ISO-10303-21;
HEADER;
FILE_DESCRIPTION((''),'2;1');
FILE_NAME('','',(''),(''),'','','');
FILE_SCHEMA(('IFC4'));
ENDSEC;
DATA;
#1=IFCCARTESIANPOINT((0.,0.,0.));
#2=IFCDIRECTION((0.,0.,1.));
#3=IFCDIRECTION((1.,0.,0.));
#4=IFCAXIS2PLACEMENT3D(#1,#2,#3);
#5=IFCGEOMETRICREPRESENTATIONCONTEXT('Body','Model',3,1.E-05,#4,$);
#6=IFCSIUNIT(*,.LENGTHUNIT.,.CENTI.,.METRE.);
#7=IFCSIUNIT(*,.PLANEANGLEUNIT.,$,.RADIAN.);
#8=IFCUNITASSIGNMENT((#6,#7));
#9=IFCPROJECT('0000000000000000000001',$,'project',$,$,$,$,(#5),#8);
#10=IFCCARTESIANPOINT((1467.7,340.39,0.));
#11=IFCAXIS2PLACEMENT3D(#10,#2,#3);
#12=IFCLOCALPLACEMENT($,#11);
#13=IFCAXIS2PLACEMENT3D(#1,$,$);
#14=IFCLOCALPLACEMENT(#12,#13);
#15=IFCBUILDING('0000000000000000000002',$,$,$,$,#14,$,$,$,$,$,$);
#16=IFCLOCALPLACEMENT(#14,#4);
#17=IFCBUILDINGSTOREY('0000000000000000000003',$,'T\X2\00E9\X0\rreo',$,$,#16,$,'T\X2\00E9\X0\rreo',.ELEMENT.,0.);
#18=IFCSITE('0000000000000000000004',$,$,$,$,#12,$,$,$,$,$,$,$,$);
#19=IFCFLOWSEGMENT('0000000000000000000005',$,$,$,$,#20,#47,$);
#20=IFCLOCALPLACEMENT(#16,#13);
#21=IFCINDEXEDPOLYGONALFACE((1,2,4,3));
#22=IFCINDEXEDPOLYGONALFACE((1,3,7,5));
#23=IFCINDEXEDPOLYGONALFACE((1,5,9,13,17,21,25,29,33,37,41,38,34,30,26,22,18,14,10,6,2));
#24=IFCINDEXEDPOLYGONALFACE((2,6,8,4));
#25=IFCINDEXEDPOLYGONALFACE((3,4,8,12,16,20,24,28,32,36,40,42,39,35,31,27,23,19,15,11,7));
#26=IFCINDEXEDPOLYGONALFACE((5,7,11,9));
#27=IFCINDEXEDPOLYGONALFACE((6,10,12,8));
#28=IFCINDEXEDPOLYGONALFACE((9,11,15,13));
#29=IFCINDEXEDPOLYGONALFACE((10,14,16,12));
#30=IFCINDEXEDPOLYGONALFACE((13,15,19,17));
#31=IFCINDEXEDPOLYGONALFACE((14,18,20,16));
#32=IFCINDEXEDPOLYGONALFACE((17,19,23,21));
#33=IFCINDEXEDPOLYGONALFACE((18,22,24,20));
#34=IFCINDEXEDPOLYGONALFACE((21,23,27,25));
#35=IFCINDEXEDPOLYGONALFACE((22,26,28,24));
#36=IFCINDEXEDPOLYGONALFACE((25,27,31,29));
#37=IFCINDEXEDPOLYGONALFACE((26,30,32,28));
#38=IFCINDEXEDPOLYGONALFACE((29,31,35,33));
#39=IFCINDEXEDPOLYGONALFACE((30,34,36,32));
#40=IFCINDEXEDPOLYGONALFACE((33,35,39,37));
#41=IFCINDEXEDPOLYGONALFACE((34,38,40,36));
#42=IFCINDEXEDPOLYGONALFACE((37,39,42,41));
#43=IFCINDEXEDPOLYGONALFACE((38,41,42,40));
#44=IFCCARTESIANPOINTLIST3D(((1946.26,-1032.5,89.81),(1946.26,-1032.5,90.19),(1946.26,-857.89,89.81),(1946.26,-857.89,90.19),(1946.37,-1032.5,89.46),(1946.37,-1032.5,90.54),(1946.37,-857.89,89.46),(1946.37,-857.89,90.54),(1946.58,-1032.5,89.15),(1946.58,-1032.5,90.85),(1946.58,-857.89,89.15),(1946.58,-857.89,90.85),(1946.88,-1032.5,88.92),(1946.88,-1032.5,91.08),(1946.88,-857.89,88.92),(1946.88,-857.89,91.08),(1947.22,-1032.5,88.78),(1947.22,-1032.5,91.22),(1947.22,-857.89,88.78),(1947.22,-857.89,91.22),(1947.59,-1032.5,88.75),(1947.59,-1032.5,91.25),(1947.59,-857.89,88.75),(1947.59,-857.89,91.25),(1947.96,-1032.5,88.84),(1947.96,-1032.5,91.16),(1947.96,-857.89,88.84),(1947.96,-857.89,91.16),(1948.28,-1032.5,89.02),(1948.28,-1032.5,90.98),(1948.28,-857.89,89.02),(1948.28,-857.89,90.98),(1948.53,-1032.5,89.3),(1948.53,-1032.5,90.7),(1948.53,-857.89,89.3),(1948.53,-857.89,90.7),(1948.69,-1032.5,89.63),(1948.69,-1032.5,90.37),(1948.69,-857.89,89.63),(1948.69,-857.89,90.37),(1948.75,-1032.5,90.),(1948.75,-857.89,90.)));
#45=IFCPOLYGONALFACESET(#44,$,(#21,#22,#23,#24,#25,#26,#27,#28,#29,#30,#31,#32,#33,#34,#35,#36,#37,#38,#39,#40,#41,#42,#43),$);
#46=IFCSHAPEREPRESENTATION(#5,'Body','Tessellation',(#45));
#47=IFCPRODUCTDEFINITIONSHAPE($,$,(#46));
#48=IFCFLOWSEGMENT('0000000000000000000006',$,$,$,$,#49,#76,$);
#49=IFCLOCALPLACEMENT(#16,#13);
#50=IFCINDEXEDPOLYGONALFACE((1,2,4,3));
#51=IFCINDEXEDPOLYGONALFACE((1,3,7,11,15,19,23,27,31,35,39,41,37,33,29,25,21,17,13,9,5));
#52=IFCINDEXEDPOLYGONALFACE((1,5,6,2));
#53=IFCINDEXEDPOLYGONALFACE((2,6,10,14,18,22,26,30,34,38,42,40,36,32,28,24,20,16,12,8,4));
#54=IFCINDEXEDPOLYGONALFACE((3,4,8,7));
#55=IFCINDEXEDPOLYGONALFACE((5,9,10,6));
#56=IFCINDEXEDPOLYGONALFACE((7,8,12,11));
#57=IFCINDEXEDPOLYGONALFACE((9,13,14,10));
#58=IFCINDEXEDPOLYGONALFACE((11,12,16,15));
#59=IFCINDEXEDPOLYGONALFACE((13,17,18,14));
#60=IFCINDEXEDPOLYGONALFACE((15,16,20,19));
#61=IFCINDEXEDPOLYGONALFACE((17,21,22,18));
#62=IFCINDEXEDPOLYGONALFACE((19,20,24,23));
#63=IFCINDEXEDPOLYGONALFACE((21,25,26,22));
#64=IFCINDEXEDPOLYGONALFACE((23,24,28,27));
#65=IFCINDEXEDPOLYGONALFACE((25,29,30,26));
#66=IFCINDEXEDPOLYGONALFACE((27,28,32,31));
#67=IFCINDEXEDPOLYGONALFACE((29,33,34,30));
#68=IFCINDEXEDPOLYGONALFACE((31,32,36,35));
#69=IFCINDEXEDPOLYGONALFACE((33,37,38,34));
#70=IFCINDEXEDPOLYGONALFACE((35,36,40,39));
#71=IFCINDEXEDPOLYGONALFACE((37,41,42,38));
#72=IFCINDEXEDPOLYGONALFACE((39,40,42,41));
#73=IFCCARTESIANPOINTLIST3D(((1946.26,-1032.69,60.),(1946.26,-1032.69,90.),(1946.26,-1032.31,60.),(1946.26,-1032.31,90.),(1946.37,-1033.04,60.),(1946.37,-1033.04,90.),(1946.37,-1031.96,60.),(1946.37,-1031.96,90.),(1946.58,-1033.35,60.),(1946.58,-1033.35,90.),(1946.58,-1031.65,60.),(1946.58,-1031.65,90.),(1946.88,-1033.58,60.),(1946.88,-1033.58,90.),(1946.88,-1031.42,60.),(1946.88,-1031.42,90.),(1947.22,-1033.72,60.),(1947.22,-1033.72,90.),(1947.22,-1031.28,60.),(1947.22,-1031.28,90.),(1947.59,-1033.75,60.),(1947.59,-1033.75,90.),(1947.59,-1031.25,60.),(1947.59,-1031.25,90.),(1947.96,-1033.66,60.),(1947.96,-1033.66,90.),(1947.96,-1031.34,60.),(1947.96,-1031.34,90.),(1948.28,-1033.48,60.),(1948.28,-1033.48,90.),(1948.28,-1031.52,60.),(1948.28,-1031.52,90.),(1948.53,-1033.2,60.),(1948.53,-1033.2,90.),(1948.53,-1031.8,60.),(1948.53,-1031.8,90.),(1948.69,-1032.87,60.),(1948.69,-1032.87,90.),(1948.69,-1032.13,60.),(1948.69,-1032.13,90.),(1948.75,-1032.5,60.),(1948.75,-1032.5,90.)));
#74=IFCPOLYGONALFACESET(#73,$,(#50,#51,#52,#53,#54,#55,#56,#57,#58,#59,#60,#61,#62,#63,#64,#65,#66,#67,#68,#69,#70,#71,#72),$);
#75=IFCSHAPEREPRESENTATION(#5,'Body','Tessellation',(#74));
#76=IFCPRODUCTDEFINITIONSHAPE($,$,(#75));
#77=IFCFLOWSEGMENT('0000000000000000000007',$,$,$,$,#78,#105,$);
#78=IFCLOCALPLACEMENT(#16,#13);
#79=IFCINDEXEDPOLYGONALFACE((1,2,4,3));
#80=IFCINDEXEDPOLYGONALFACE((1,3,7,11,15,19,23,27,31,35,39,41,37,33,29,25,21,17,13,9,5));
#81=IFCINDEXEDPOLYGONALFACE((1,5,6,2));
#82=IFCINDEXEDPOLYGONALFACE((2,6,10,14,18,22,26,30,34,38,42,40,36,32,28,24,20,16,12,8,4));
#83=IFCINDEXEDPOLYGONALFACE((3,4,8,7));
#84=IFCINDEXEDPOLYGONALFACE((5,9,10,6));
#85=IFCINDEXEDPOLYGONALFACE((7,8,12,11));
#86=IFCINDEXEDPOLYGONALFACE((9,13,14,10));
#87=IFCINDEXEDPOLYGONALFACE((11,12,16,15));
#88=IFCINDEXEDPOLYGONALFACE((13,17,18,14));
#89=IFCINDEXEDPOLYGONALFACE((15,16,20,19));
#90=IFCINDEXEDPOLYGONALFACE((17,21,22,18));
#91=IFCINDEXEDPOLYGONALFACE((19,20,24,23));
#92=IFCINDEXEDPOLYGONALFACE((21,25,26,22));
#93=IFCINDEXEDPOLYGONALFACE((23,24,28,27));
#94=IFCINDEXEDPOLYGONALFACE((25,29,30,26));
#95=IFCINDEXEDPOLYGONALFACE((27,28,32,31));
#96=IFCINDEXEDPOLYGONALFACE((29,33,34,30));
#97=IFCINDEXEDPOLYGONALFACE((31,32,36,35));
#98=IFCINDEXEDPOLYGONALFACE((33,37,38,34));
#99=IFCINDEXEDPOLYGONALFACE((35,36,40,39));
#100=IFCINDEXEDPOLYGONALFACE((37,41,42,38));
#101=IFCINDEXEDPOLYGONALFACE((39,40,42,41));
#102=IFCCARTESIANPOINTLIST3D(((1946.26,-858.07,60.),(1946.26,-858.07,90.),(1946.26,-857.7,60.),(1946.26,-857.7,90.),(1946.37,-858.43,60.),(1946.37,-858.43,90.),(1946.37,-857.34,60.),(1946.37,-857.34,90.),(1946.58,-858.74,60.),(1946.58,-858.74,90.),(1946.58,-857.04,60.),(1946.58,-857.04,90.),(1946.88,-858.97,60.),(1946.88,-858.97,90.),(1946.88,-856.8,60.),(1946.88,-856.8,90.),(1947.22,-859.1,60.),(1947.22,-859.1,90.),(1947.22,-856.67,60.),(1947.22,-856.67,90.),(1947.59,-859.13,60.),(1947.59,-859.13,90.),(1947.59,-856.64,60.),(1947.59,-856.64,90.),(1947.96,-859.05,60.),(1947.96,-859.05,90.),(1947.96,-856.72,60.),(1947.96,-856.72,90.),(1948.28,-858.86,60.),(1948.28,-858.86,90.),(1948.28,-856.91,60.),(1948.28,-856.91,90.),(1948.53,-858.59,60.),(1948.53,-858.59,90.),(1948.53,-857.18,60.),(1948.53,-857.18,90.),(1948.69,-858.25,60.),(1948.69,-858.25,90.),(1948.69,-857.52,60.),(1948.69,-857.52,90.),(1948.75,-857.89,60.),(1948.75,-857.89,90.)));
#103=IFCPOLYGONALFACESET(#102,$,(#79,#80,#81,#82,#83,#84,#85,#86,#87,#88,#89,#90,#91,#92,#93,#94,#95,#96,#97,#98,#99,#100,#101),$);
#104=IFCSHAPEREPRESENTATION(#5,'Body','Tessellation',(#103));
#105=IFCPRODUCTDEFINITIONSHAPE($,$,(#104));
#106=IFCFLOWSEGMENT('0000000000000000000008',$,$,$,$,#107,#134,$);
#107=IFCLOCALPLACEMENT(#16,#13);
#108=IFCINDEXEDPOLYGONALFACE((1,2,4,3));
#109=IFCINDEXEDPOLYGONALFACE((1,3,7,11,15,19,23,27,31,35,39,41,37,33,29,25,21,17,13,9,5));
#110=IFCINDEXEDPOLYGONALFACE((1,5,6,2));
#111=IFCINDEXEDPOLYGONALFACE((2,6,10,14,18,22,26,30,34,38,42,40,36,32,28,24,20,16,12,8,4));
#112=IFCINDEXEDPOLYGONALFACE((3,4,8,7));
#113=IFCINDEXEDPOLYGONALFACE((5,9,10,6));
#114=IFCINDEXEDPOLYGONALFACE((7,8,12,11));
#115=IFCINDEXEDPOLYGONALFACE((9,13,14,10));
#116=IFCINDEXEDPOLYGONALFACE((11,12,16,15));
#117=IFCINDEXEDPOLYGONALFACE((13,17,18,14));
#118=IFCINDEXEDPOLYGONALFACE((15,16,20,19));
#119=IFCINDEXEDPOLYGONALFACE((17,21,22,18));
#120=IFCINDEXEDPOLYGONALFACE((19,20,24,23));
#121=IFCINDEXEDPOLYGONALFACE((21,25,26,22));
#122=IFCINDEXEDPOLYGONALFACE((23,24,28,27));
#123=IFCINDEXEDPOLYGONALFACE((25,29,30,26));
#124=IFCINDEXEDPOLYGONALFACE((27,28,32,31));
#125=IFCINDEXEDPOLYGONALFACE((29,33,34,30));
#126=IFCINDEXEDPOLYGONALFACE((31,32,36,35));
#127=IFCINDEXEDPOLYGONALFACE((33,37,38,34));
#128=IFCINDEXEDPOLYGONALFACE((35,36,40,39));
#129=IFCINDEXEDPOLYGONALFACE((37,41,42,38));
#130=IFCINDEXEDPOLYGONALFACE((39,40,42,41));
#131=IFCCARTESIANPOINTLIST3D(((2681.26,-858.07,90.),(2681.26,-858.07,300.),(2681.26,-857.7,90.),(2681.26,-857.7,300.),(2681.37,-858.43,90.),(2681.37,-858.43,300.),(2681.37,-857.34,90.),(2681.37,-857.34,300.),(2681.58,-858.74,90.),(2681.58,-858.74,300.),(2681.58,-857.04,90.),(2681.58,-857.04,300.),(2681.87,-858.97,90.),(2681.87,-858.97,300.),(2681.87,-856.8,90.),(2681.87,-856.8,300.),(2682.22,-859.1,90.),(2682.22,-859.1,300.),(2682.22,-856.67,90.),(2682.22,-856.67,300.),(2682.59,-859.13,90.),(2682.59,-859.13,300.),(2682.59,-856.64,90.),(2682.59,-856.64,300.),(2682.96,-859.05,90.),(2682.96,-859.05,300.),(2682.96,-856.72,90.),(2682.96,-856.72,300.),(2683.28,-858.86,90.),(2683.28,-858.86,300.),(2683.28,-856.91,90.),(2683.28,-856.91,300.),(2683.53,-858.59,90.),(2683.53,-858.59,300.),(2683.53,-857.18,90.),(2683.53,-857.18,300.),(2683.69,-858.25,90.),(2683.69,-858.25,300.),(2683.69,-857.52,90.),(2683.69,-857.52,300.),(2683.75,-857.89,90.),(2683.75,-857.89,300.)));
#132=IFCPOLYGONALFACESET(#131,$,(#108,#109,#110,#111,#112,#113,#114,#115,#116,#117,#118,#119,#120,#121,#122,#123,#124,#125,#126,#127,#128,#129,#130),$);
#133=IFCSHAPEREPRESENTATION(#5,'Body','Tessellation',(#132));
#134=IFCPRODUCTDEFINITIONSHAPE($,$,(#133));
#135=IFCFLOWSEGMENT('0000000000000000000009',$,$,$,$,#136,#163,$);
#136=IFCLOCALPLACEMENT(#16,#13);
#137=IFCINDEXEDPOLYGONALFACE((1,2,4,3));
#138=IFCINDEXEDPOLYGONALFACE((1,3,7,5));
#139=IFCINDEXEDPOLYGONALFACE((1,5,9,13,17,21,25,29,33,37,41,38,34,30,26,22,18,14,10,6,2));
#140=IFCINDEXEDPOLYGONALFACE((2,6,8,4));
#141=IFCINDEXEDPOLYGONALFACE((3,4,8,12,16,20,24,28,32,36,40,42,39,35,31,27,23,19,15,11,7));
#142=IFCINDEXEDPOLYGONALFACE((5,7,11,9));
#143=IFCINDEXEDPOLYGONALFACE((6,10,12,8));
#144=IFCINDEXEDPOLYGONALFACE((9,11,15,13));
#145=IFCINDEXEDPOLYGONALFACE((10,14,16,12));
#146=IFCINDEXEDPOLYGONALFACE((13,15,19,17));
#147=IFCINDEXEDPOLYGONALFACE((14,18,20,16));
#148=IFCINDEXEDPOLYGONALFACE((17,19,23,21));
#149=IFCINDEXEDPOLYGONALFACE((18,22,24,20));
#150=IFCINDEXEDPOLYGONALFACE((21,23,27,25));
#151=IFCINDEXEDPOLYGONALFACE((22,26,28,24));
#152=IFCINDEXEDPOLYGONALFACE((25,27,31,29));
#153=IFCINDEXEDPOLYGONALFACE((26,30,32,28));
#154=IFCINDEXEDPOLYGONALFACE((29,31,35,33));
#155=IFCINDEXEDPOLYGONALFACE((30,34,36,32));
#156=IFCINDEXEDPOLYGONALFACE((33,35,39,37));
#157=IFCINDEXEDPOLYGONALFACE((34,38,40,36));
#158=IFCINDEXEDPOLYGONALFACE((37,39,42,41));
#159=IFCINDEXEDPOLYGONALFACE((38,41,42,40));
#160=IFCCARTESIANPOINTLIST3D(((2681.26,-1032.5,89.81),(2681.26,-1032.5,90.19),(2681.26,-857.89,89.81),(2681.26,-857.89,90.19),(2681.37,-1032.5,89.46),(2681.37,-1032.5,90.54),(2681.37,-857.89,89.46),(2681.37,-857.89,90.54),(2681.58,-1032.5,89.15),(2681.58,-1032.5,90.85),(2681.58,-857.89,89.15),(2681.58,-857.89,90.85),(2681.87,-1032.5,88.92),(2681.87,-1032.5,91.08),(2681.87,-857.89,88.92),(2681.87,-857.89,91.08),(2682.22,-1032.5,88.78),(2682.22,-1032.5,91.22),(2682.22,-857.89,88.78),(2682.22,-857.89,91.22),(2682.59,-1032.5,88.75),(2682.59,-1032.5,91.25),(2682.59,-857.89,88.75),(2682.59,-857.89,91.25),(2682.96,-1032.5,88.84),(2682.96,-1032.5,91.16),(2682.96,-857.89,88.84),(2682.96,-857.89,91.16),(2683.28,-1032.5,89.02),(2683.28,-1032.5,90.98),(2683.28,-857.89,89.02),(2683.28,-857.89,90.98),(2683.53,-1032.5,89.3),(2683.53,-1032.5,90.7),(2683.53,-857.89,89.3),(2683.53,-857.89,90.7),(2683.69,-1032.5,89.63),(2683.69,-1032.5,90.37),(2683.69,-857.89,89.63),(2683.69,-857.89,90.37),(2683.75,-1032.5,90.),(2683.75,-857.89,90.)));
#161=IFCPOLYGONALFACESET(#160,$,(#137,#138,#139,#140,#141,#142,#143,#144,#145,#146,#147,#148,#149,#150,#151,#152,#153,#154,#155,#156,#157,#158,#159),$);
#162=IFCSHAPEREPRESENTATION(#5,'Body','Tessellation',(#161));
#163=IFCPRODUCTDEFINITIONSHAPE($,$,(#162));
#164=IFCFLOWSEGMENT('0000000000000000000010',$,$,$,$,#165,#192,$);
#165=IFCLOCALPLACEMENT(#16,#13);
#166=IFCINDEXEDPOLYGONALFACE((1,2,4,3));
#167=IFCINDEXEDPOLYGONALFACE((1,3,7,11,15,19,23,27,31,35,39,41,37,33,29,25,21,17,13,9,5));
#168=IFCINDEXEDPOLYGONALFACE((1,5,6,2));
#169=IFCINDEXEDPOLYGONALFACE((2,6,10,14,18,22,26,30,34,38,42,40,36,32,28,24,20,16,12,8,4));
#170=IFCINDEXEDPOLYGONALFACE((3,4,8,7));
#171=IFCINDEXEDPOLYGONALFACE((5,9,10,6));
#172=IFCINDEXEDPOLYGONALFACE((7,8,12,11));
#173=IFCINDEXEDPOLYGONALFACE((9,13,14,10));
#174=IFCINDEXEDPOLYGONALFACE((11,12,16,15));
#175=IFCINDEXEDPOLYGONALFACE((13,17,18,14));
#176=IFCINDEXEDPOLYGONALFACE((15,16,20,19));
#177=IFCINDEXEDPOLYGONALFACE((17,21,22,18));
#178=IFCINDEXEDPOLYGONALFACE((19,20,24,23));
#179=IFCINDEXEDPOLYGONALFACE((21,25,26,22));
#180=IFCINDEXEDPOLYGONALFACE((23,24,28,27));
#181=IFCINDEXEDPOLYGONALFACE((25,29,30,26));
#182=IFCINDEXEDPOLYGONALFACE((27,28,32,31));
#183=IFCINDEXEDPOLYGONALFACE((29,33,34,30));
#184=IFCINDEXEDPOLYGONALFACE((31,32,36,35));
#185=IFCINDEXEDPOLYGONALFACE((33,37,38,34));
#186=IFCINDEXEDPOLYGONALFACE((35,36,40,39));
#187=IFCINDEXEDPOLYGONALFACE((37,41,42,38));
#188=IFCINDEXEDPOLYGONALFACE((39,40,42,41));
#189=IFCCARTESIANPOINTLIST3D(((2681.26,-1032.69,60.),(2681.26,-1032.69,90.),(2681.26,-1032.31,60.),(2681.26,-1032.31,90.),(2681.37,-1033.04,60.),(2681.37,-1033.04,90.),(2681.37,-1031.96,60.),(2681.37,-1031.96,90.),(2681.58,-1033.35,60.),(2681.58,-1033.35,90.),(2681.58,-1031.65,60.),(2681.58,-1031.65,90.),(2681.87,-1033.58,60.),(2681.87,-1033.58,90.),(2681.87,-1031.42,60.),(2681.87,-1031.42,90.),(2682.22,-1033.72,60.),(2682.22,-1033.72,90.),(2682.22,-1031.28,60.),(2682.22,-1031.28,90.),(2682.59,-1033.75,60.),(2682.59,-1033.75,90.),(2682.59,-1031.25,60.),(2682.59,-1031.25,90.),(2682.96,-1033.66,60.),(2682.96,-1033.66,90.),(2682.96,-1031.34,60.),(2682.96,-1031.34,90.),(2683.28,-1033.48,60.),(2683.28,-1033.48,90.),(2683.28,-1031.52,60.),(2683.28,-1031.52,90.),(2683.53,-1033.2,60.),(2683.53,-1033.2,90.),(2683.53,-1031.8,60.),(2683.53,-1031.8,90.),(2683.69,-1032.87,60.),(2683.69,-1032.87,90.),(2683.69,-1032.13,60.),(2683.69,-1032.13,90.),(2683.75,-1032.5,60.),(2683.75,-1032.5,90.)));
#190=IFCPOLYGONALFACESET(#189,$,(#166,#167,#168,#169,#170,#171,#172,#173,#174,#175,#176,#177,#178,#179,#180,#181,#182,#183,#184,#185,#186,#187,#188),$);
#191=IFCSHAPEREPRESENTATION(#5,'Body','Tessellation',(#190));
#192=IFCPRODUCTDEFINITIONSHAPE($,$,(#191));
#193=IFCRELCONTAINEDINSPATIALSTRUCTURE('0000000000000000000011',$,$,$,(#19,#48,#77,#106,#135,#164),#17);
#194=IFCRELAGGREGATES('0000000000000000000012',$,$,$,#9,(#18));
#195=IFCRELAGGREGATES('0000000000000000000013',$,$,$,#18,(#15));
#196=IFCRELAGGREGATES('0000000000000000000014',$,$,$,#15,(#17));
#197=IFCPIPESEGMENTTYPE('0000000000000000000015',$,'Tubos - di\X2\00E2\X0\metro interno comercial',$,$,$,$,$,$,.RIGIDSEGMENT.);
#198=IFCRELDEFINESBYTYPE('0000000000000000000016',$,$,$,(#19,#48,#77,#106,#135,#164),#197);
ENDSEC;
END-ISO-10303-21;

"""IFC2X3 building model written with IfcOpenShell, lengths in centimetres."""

from ifc_helpers import new_model, si_unit, frame, origin, origin_with_axes, origin_2d_with_axis, place, context, project, spatial, circle, extrude, type_object, element, save


model = new_model("IFC2X3")

# Units and contexts
model_context = context("Model", 3, precision=1e-05, world=origin_with_axes(), identifier="Body")
ifc_project = project(units=[si_unit("LENGTHUNIT", "METRE", prefix="CENTI"), si_unit("PLANEANGLEUNIT", "RADIAN")], contexts=[model_context])

# Site, building, storey
site_placement = place(None, frame((1467.7, 340.39, 0.0), z_axis=(0.0, 0.0, 1.0), x_axis=(1.0, 0.0, 0.0)))
site = spatial("IfcSite", under=ifc_project, at=site_placement)
building_placement = place(site_placement, origin())
building = spatial("IfcBuilding", under=site, at=building_placement)
storey_placement = place(building_placement, origin_with_axes())
storey = spatial("IfcBuildingStorey", under=building, at=storey_placement, Name="Térreo", LongName="Térreo", CompositionType="ELEMENT", Elevation=0.0)

# Flow segments
pipe_segment_type_1 = type_object("IfcPipeSegmentType", Name="Tubos - diâmetro interno comercial", PredefinedType="RIGIDSEGMENT")
flow_segment_1_placement = place(storey_placement, frame((1947.5, -945.19, 91.25), z_axis=(0.0, 0.0, 1.0), x_axis=(1.0, 0.0, 0.0)))
element("IfcFlowSegment", 1, at=flow_segment_1_placement, inside=storey, type_object=pipe_segment_type_1, context=model_context, shape_type="SolidModel", body=[
    extrude(circle(Radius=1.25, at=origin_2d_with_axis()), frame((0.0, 87.31, -1.25), z_axis=(0.0, -1.0, 0.0), x_axis=(1.0, 0.0, 0.0)), (0.0, 0.0, 1.0), 174.61),
])
for number, where, z_axis, x_axis in (
    (2, (1947.5, -1032.5, 90.0), (0.0, 0.0, 1.0), (1.0, 0.0, 0.0)),
    (3, (1947.5, -857.89, 90.0), (0.0, 0.0, 1.0), (1.0, 0.0, 0.0)),
):
    element("IfcFlowSegment", number, at=place(storey_placement, frame(where, z_axis=z_axis, x_axis=x_axis)), inside=storey, type_object=pipe_segment_type_1, context=model_context, shape_type="SolidModel", body=[
        extrude(circle(Radius=1.25, at=origin_2d_with_axis()), frame((0.0, 0.0, 0.0), z_axis=(0.0, 0.0, -1.0), x_axis=(1.0, 0.0, 0.0)), (0.0, 0.0, 1.0), 30.0),
    ])
flow_segment_2_placement = place(storey_placement, frame((2682.5, -857.89, 300.0), z_axis=(0.0, 0.0, 1.0), x_axis=(1.0, 0.0, 0.0)))
element("IfcFlowSegment", 4, at=flow_segment_2_placement, inside=storey, type_object=pipe_segment_type_1, context=model_context, shape_type="SolidModel", body=[
    extrude(circle(Radius=1.25, at=origin_2d_with_axis()), frame((0.0, 0.0, 0.0), z_axis=(0.0, 0.0, -1.0), x_axis=(1.0, 0.0, 0.0)), (0.0, 0.0, 1.0), 210.0),
])
flow_segment_3_placement = place(storey_placement, frame((2682.5, -945.19, 91.25), z_axis=(0.0, 0.0, 1.0), x_axis=(1.0, 0.0, 0.0)))
element("IfcFlowSegment", 5, at=flow_segment_3_placement, inside=storey, type_object=pipe_segment_type_1, context=model_context, shape_type="SolidModel", body=[
    extrude(circle(Radius=1.25, at=origin_2d_with_axis()), frame((0.0, 87.31, -1.25), z_axis=(0.0, -1.0, 0.0), x_axis=(1.0, 0.0, 0.0)), (0.0, 0.0, 1.0), 174.61),
])
for number, where, z_axis, x_axis in (
    (6, (2682.5, -1032.5, 90.0), (0.0, 0.0, 1.0), (1.0, 0.0, 0.0)),
):
    element("IfcFlowSegment", number, at=place(storey_placement, frame(where, z_axis=z_axis, x_axis=x_axis)), inside=storey, type_object=pipe_segment_type_1, context=model_context, shape_type="SolidModel", body=[
        extrude(circle(Radius=1.25, at=origin_2d_with_axis()), frame((0.0, 0.0, 0.0), z_axis=(0.0, 0.0, -1.0), x_axis=(1.0, 0.0, 0.0)), (0.0, 0.0, 1.0), 30.0),
    ])

save(model, "model.ifc")
